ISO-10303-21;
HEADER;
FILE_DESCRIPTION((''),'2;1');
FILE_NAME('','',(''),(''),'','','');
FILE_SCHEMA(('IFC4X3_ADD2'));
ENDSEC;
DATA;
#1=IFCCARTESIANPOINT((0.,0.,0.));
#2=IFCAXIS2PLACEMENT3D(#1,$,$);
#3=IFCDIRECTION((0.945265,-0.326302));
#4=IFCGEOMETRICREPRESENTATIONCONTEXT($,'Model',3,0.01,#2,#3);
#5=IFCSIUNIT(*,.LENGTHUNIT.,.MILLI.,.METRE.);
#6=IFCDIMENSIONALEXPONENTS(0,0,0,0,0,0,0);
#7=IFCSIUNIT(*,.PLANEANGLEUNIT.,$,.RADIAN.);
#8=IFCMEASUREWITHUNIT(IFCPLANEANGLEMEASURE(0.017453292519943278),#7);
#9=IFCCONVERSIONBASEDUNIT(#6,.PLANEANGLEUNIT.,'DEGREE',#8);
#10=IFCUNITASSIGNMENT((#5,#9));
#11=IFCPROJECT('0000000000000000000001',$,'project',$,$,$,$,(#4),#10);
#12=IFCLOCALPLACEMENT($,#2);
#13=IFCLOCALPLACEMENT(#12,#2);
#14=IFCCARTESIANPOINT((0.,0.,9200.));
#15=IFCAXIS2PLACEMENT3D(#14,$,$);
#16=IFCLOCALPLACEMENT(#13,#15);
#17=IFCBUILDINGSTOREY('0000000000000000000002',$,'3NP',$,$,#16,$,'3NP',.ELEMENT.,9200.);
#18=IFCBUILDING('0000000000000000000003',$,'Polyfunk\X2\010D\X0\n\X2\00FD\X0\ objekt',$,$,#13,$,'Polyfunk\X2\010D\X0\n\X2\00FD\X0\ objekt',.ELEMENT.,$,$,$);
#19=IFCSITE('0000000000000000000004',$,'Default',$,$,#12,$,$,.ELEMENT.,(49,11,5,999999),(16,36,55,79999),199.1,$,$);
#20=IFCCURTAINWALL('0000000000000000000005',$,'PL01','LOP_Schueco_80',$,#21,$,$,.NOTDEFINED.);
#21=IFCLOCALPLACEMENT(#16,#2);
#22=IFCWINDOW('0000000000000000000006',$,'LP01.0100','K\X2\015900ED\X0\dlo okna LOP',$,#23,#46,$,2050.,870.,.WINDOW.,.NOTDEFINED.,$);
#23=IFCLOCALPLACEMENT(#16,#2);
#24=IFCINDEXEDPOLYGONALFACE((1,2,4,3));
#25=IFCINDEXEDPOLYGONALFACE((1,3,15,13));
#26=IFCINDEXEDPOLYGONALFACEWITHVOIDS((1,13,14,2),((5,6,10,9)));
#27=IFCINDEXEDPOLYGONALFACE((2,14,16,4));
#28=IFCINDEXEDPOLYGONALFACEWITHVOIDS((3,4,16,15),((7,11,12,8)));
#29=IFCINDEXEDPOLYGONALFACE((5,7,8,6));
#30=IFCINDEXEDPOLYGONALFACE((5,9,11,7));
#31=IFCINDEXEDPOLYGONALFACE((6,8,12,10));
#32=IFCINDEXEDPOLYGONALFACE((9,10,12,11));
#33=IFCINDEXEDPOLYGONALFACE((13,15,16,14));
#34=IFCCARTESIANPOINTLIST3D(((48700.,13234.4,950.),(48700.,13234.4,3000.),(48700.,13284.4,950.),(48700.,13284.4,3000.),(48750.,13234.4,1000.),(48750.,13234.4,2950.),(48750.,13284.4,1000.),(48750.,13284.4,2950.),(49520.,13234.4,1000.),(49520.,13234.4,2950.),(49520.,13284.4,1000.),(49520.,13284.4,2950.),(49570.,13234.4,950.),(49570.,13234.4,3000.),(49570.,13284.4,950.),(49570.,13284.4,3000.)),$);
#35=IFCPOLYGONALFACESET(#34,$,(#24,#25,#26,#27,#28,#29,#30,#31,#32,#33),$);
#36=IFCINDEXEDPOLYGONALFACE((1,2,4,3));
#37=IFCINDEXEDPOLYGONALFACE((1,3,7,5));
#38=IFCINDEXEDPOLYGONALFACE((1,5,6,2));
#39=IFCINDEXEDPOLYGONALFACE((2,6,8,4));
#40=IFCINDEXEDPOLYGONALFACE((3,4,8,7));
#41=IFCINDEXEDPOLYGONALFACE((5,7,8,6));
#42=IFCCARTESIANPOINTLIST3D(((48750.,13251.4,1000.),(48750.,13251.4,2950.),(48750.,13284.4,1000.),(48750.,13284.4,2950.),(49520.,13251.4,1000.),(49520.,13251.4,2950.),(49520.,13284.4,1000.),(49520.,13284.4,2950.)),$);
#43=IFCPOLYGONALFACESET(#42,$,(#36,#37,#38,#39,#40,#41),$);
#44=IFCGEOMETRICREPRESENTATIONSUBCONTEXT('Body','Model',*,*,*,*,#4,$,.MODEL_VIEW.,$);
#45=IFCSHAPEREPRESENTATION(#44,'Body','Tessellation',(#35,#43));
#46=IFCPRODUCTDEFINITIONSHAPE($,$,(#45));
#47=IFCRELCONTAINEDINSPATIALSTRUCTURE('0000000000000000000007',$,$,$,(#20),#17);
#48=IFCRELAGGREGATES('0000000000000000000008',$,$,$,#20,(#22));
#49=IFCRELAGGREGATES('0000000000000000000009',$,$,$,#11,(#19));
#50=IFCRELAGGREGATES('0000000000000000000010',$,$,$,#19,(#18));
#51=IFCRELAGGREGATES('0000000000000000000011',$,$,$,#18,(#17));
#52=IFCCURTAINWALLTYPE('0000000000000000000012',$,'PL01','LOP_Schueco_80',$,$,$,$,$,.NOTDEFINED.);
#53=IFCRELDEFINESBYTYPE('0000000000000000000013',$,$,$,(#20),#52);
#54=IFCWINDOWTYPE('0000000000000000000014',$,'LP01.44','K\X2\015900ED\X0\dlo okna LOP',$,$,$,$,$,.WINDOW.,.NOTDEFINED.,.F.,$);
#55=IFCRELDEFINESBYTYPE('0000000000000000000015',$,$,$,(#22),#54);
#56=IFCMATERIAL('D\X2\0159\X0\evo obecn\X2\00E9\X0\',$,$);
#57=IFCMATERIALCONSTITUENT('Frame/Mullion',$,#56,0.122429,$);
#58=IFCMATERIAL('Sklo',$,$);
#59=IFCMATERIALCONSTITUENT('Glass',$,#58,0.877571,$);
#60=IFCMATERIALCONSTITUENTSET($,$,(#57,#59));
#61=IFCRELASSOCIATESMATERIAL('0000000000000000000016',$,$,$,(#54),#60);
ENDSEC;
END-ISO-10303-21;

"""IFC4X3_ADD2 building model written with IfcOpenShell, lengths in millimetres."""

from ifc_helpers import new_model, entity, si_unit, converted_unit, direction, frame, origin, origin_2d_with_axis, place, context, subcontext, project, spatial, polyline, rectangle, outline, extrude, source, transform, mapped, material, constituent, constituent_set, type_object, type_shapes, element, aggregate, save


model = new_model("IFC4X3_ADD2")

# Units and contexts
model_context = context("Model", 3, precision=0.01, world=origin(), true_north=direction((0.945265, -0.326302)))
body_context = subcontext(model_context, "Body", "Model", "MODEL_VIEW")
ifc_project = project(units=[si_unit("LENGTHUNIT", "METRE", prefix="MILLI"), converted_unit("PLANEANGLEUNIT", "DEGREE", entity("IfcPlaneAngleMeasure", 0.017453292519943278), si_unit("PLANEANGLEUNIT", "RADIAN"), dimensions=[0, 0, 0, 0, 0, 0, 0])], contexts=[model_context])

# Site, building, storey
site_placement = place(None, origin())
site = spatial("IfcSite", under=ifc_project, at=site_placement, Name="Default", CompositionType="ELEMENT", RefLatitude=(49, 11, 5, 999999), RefLongitude=(16, 36, 55, 79999), RefElevation=199.1)
building_placement = place(site_placement, origin())
building = spatial("IfcBuilding", under=site, at=building_placement, Name="Polyfunkčný objekt", LongName="Polyfunkčný objekt", CompositionType="ELEMENT")
storey_placement = place(building_placement, frame((0.0, 0.0, 9200.0)))
storey = spatial("IfcBuildingStorey", under=building, at=storey_placement, Name="3NP", LongName="3NP", CompositionType="ELEMENT", Elevation=9200.0)

# Curtain wall
curtain_wall_type = type_object("IfcCurtainWallType", Name="PL01", Description="LOP_Schueco_80", PredefinedType="NOTDEFINED")
curtain_wall_placement = place(storey_placement, frame((0.0, 0.0, -9200.0)))
curtain_wall = element("IfcCurtainWall", 1, at=curtain_wall_placement, inside=storey, type_object=curtain_wall_type, Name="PL01", Description="LOP_Schueco_80", PredefinedType="NOTDEFINED")
ifc_material_1 = material(Name="Sklo")

# Window
ifc_material_2 = material(Name="Dřevo obecné")
ifc_constituent_1 = constituent(ifc_material_2, Name="Frame/Mullion", fraction=0.122429)
ifc_constituent_2 = constituent(ifc_material_1, Name="Glass", fraction=0.877571)
ifc_constituent_set = constituent_set(constituents=[ifc_constituent_1, ifc_constituent_2])
window_type = type_object("IfcWindowType", Name="LP01.44", Description="Křídlo okna LOP", ParameterTakesPrecedence=False, PartitioningType="NOTDEFINED", PredefinedType="WINDOW", material=ifc_constituent_set)
shared_shape_1 = source(origin(), body_context, "Body", "SweptSolid", [
    extrude(outline(polyline([(-1025.0, -435.0), (1025.0, -435.0), (1025.0, 435.0), (-1025.0, 435.0), (-1025.0, -435.0)]), holes=[polyline([(-975.0, -385.0), (-975.0, 385.0), (975.0, 385.0), (975.0, -385.0), (-975.0, -385.0)])]), frame((0.0, 0.0, 1025.0), z_axis=(0.0, 1.0, 0.0), x_axis=(0.0, 0.0, -1.0)), (0.0, 0.0, 1.0), 50.0),
    extrude(rectangle(XDim=33.0, YDim=770.0, at=origin_2d_with_axis()), frame((0.0, 33.5, 50.0), z_axis=(0.0, 0.0, 1.0), x_axis=(0.0, -1.0, 0.0)), (0.0, 0.0, 1.0), 1950.0),
])
type_shapes(window_type, [shared_shape_1])
window_placement = place(curtain_wall_placement, frame((49135.0, 13234.4, 10150.0)))
window = element("IfcWindow", 2, at=window_placement, type_object=window_type, Name="LP01.0100", Description="Křídlo okna LOP", OverallHeight=2050.0, OverallWidth=870.0, PartitioningType="NOTDEFINED", PredefinedType="WINDOW", context=body_context, shape_type="MappedRepresentation", body=[
    mapped(shared_shape_1, transform((0.0, 0.0, 0.0), scale=1.0)),
])
aggregate(curtain_wall, [window])

save(model, "model.ifc")
